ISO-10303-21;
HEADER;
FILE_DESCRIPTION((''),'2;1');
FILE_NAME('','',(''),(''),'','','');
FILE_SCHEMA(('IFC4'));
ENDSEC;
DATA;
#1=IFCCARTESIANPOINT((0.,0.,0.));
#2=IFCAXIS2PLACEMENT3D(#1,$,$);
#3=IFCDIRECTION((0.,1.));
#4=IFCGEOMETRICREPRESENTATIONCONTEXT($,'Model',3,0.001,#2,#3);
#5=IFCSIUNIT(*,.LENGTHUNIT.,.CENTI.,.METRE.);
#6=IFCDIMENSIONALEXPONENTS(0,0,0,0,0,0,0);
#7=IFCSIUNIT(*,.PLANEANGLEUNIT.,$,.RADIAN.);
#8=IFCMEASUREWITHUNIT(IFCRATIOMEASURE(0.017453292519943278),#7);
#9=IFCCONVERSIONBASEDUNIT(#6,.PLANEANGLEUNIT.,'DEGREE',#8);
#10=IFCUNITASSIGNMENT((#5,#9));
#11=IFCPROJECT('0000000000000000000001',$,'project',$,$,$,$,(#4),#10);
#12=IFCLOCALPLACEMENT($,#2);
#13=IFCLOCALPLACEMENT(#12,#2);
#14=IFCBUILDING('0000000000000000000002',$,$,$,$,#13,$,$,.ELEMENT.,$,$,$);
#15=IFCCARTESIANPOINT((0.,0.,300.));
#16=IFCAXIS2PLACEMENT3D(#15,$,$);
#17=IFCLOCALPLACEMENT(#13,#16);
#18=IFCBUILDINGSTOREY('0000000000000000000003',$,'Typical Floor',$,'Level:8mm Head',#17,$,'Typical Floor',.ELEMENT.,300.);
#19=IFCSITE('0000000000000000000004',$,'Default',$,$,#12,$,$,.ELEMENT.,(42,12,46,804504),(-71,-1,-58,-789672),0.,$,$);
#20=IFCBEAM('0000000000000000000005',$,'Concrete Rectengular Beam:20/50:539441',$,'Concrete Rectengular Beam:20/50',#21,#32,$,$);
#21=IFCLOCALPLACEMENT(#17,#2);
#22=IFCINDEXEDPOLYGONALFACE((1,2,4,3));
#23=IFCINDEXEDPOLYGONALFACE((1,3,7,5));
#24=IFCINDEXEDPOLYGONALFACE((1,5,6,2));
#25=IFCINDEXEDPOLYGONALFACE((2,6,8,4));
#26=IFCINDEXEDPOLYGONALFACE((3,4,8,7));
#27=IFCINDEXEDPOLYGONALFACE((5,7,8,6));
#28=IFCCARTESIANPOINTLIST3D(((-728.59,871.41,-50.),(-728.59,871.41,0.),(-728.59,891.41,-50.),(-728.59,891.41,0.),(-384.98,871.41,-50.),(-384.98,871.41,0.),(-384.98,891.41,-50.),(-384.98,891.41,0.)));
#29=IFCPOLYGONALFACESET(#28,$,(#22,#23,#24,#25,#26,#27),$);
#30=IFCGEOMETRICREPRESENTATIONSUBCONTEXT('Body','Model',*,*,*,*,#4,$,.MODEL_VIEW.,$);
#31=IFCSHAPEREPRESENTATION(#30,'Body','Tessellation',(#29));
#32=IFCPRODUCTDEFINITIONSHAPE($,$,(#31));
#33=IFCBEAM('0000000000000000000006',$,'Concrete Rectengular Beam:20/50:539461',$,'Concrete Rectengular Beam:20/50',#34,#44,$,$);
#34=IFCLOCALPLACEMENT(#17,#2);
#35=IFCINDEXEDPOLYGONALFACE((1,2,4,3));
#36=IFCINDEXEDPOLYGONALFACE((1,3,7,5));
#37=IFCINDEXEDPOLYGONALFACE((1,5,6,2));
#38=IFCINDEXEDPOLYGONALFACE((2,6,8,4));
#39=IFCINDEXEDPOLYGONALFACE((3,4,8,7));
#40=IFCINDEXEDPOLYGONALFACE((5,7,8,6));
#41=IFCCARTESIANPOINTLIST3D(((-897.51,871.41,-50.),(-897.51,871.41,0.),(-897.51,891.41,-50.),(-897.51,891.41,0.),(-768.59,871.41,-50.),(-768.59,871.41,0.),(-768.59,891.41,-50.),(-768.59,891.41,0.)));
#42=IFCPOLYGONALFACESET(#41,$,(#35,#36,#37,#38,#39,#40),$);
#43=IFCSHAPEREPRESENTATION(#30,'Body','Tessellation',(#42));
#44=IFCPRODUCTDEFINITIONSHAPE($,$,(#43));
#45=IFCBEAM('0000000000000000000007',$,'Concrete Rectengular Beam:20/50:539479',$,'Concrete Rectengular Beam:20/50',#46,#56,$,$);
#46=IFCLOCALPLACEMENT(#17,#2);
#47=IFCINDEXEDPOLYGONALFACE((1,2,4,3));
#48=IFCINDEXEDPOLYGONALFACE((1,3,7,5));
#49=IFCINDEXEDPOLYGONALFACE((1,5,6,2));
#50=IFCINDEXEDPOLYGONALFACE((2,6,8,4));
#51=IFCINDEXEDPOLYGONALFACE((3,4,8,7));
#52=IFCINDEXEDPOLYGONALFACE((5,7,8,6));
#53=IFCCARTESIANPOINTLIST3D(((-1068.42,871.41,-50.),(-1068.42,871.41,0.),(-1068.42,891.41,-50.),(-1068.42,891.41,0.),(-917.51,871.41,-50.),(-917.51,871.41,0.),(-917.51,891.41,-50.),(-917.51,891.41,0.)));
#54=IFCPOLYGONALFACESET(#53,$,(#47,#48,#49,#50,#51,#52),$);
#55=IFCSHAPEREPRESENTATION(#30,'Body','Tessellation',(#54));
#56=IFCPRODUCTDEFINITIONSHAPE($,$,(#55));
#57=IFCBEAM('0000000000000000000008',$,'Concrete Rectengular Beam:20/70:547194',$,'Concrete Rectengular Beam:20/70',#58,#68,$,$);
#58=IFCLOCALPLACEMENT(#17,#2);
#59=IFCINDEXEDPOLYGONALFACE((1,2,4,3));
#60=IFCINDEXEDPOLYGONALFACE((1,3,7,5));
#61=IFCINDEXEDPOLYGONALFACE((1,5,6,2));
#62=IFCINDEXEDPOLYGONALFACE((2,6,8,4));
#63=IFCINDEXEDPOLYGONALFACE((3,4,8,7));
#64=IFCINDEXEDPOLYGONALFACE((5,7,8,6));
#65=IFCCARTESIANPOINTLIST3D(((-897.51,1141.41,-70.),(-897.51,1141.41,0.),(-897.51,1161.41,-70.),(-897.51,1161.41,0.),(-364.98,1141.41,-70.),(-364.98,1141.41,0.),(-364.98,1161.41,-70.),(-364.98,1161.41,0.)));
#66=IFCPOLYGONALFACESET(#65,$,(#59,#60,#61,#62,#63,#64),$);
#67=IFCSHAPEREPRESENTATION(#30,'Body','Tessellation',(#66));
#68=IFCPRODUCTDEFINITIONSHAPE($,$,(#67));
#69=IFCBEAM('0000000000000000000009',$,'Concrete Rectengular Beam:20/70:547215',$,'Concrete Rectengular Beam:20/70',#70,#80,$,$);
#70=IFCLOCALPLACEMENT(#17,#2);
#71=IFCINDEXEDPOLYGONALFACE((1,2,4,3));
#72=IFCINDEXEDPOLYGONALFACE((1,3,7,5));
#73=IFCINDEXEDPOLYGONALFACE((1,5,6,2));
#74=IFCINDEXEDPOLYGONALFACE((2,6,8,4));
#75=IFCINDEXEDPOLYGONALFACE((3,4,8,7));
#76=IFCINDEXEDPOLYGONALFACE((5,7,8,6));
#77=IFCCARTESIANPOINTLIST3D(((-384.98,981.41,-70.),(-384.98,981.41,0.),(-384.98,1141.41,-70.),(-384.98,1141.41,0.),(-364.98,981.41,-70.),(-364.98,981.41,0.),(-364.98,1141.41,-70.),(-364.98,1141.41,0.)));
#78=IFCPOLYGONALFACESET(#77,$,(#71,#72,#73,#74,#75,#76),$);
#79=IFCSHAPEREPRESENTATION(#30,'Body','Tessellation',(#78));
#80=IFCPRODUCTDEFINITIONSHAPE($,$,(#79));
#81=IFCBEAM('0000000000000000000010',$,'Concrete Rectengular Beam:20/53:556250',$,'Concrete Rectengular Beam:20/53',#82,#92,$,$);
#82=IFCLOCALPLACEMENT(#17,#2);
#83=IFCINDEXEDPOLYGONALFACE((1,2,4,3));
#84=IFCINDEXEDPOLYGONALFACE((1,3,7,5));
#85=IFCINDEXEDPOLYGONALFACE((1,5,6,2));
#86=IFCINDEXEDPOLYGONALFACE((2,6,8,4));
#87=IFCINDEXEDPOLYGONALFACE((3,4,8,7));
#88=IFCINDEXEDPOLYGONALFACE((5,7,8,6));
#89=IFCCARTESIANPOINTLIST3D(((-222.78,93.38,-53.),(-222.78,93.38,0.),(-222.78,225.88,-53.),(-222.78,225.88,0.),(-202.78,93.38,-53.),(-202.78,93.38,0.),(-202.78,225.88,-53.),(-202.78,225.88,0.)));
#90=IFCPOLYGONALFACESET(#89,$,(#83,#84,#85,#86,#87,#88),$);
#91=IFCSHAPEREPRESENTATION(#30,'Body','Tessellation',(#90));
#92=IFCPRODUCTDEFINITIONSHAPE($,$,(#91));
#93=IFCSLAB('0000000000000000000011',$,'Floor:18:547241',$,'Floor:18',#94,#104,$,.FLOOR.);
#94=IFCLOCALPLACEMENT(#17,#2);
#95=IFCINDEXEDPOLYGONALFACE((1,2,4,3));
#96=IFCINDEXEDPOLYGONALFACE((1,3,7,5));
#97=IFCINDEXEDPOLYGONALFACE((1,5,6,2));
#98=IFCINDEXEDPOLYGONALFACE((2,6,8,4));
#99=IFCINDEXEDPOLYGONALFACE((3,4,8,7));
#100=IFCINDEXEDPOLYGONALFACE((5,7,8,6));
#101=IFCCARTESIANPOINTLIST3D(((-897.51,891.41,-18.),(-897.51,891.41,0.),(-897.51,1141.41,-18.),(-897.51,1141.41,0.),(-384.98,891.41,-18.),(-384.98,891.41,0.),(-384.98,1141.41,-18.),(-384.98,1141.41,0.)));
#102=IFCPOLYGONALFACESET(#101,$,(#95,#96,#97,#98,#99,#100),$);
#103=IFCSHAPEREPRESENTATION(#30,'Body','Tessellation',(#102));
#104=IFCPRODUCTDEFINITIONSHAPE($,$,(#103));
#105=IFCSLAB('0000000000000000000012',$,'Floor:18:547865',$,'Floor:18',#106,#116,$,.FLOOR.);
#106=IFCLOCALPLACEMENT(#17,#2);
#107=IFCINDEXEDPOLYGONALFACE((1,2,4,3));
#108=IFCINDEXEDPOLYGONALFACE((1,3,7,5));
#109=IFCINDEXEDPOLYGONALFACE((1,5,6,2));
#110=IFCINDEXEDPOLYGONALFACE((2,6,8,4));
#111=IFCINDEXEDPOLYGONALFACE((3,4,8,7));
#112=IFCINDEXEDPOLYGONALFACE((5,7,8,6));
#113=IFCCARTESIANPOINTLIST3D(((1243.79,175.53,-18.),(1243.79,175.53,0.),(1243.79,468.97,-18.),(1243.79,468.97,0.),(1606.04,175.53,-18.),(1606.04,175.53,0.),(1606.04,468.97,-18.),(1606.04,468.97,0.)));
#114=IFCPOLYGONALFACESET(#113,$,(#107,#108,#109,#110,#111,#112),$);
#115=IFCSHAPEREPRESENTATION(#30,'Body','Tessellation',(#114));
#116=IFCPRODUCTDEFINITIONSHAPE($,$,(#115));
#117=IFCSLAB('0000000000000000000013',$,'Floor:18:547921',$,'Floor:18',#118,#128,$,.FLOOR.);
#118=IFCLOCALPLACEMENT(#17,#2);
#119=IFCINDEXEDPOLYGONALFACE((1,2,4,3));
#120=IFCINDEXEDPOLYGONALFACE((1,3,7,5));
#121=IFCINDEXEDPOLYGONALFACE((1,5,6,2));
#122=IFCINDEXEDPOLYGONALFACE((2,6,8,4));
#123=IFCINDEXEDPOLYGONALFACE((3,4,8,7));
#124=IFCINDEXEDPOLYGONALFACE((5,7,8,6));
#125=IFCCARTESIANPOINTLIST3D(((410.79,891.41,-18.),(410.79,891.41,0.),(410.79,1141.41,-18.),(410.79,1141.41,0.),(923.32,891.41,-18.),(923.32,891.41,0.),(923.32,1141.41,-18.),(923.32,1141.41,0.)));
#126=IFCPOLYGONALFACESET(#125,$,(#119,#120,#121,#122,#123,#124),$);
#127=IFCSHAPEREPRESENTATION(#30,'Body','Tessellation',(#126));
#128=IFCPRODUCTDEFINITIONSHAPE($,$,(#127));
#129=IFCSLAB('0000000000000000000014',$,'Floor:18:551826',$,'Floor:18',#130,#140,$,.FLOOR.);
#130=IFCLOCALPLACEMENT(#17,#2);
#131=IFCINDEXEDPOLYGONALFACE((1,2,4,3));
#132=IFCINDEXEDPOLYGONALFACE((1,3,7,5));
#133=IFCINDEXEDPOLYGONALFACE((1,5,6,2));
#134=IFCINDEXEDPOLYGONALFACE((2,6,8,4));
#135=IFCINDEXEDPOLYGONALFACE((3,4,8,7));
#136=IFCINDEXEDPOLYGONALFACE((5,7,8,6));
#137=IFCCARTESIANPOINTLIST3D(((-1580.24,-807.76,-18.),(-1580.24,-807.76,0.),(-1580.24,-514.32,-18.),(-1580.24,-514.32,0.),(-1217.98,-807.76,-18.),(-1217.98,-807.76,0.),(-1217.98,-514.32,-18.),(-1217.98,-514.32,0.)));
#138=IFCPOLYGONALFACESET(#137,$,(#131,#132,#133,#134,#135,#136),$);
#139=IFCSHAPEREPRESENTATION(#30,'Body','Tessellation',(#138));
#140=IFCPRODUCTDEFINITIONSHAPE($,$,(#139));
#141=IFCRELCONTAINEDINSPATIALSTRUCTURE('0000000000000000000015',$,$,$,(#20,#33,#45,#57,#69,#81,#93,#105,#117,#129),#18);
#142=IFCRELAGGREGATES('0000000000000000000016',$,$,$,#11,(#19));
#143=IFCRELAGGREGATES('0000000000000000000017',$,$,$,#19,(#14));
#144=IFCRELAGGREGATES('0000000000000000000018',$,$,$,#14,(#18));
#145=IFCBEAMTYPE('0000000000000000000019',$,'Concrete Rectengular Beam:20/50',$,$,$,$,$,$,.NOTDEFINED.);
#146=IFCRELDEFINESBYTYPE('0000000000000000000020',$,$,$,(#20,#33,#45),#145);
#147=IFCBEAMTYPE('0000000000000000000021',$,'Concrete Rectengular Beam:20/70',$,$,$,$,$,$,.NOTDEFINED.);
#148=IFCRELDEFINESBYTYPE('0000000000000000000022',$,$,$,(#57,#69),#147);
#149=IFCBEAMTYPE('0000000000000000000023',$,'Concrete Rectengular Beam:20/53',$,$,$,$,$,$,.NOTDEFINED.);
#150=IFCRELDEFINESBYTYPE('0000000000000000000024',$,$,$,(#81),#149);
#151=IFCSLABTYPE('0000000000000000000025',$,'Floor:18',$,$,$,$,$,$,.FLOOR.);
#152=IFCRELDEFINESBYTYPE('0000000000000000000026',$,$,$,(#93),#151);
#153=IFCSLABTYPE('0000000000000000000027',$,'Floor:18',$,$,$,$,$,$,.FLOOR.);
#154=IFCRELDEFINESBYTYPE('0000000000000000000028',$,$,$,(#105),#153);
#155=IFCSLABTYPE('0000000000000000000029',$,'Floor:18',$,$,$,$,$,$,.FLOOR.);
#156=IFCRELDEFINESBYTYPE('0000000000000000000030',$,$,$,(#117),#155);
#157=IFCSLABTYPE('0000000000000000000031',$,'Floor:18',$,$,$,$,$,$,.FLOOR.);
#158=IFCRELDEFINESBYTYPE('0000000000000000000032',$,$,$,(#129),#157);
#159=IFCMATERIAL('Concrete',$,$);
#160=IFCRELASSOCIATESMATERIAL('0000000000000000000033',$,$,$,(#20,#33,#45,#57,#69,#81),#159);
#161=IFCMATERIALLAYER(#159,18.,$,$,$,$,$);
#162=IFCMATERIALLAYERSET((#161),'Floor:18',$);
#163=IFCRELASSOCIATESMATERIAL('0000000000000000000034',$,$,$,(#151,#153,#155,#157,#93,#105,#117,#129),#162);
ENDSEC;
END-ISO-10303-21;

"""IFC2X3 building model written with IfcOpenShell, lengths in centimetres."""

from ifc_helpers import new_model, entity, si_unit, converted_unit, direction, frame, frame_2d, origin, origin_2d_with_axis, place, context, subcontext, project, spatial, rectangle, extrude, material, layer, layer_set, layer_usage, type_object, element, save


model = new_model("IFC2X3")

# Units and contexts
model_context = context("Model", 3, precision=0.001, world=origin(), true_north=direction((0.0, 1.0)))
body_context = subcontext(model_context, "Body", "Model", "MODEL_VIEW")
ifc_project = project(units=[si_unit("LENGTHUNIT", "METRE", prefix="CENTI"), converted_unit("PLANEANGLEUNIT", "DEGREE", entity("IfcRatioMeasure", 0.017453292519943278), si_unit("PLANEANGLEUNIT", "RADIAN"), dimensions=[0, 0, 0, 0, 0, 0, 0])], contexts=[model_context])

# Site, building, storey
site_placement = place(None, origin())
site = spatial("IfcSite", under=ifc_project, at=site_placement, Name="Default", CompositionType="ELEMENT", RefLatitude=(42, 12, 46, 804504), RefLongitude=(-71, -1, -58, -789672), RefElevation=0.0)
building_placement = place(site_placement, origin())
building = spatial("IfcBuilding", under=site, at=building_placement, CompositionType="ELEMENT")
storey_placement = place(building_placement, frame((0.0, 0.0, 300.0)))
storey = spatial("IfcBuildingStorey", under=building, at=storey_placement, Name="Typical Floor", ObjectType="Level:8mm Head", LongName="Typical Floor", CompositionType="ELEMENT", Elevation=300.0)

# Beams
ifc_material = material(Name="Concrete")
beam_type_1 = type_object("IfcBeamType", Name="Concrete Rectengular Beam:20/50", PredefinedType="NOTDEFINED")
beam_1_placement = place(storey_placement, frame((-374.98, 881.41, 0.0), z_axis=(0.0, 0.0, 1.0), x_axis=(-1.0, 0.0, 0.0)))
element("IfcBeam", 1, at=beam_1_placement, inside=storey, type_object=beam_type_1, material=ifc_material, Name="Concrete Rectengular Beam:20/50:539441", ObjectType="Concrete Rectengular Beam:20/50", context=body_context, shape_type="SweptSolid", body=[
    extrude(rectangle(XDim=50.0, YDim=20.0, at=frame_2d((0.0, 0.0), x_axis=(1.0, 0.0))), frame((10.0, 0.0, -25.0), z_axis=(1.0, 0.0, 0.0), x_axis=(0.0, 0.0, -1.0)), (0.0, 0.0, 1.0), 343.61),
])
beam_2_placement = place(storey_placement, frame((-748.59, 881.41, 0.0), z_axis=(0.0, 0.0, 1.0), x_axis=(-1.0, 0.0, 0.0)))
element("IfcBeam", 2, at=beam_2_placement, inside=storey, type_object=beam_type_1, material=ifc_material, Name="Concrete Rectengular Beam:20/50:539461", ObjectType="Concrete Rectengular Beam:20/50", context=body_context, shape_type="SweptSolid", body=[
    extrude(rectangle(XDim=50.0, YDim=20.0, at=frame_2d((0.0, 0.0), x_axis=(1.0, 0.0))), frame((20.0, 0.0, -25.0), z_axis=(1.0, 0.0, 0.0), x_axis=(0.0, 0.0, -1.0)), (0.0, 0.0, 1.0), 128.92),
])
beam_3_placement = place(storey_placement, frame((-907.51, 881.41, 0.0), z_axis=(0.0, 0.0, 1.0), x_axis=(-1.0, 0.0, 0.0)))
element("IfcBeam", 3, at=beam_3_placement, inside=storey, type_object=beam_type_1, material=ifc_material, Name="Concrete Rectengular Beam:20/50:539479", ObjectType="Concrete Rectengular Beam:20/50", context=body_context, shape_type="SweptSolid", body=[
    extrude(rectangle(XDim=50.0, YDim=20.0, at=frame_2d((0.0, 0.0), x_axis=(1.0, 0.0))), frame((10.0, 0.0, -25.0), z_axis=(1.0, 0.0, 0.0), x_axis=(0.0, 0.0, -1.0)), (0.0, 0.0, 1.0), 150.91),
])
beam_type_2 = type_object("IfcBeamType", Name="Concrete Rectengular Beam:20/70", PredefinedType="NOTDEFINED")
beam_4_placement = place(storey_placement, frame((-907.51, 1151.41, 0.0)))
element("IfcBeam", 4, at=beam_4_placement, inside=storey, type_object=beam_type_2, material=ifc_material, Name="Concrete Rectengular Beam:20/70:547194", ObjectType="Concrete Rectengular Beam:20/70", context=body_context, shape_type="SweptSolid", body=[
    extrude(rectangle(XDim=70.0, YDim=20.0, at=frame_2d((0.0, 0.0), x_axis=(1.0, 0.0))), frame((10.0, 0.0, -35.0), z_axis=(1.0, 0.0, 0.0), x_axis=(0.0, 0.0, -1.0)), (0.0, 0.0, 1.0), 532.53),
])
beam_5_placement = place(storey_placement, frame((-374.98, 1151.41, 0.0), z_axis=(0.0, 0.0, 1.0), x_axis=(0.0, -1.0, 0.0)))
element("IfcBeam", 5, at=beam_5_placement, inside=storey, type_object=beam_type_2, material=ifc_material, Name="Concrete Rectengular Beam:20/70:547215", ObjectType="Concrete Rectengular Beam:20/70", context=body_context, shape_type="SweptSolid", body=[
    extrude(rectangle(XDim=70.0, YDim=20.0, at=origin_2d_with_axis()), frame((10.0, 0.0, -35.0), z_axis=(1.0, 0.0, 0.0), x_axis=(0.0, 0.0, -1.0)), (0.0, 0.0, 1.0), 160.0),
])
beam_type_3 = type_object("IfcBeamType", Name="Concrete Rectengular Beam:20/53", PredefinedType="NOTDEFINED")
beam_6_placement = place(storey_placement, frame((-212.78, 225.88, 0.0), z_axis=(0.0, 0.0, 1.0), x_axis=(0.0, -1.0, 0.0)))
element("IfcBeam", 6, at=beam_6_placement, inside=storey, type_object=beam_type_3, material=ifc_material, Name="Concrete Rectengular Beam:20/53:556250", ObjectType="Concrete Rectengular Beam:20/53", context=body_context, shape_type="SweptSolid", body=[
    extrude(rectangle(XDim=53.0, YDim=20.0, at=origin_2d_with_axis()), frame((0.0, 0.0, -26.5), z_axis=(1.0, 0.0, 0.0), x_axis=(0.0, 0.0, -1.0)), (0.0, 0.0, 1.0), 132.5),
])

# Slabs
ifc_layer = layer(ifc_material, 18.0)
ifc_layer_set = layer_set([ifc_layer], Name="Floor:18")
ifc_layer_usage_1 = layer_usage(ifc_layer_set, "AXIS3", "POSITIVE", 0.0)
slab_type_1 = type_object("IfcSlabType", Name="Floor:18", PredefinedType="FLOOR", material=ifc_layer_set)
slab_1_placement = place(storey_placement, origin())
element("IfcSlab", 7, at=slab_1_placement, inside=storey, type_object=slab_type_1, material=ifc_layer_usage_1, Name="Floor:18:547241", ObjectType="Floor:18", PredefinedType="FLOOR", context=body_context, shape_type="SweptSolid", body=[
    extrude(rectangle(XDim=250.0, YDim=512.53, at=frame_2d((0.0, 0.0), x_axis=(1.0, 0.0))), frame((-641.25, 1016.41, 0.0), z_axis=(0.0, 0.0, -1.0), x_axis=(0.0, 1.0, 0.0)), (0.0, 0.0, 1.0), 18.0),
])
ifc_layer_usage_2 = layer_usage(ifc_layer_set, "AXIS3", "POSITIVE", 0.0)
slab_type_2 = type_object("IfcSlabType", Name="Floor:18", PredefinedType="FLOOR", material=ifc_layer_set)
slab_2_placement = place(storey_placement, origin())
element("IfcSlab", 8, at=slab_2_placement, inside=storey, type_object=slab_type_2, material=ifc_layer_usage_2, Name="Floor:18:547865", ObjectType="Floor:18", PredefinedType="FLOOR", context=body_context, shape_type="SweptSolid", body=[
    extrude(rectangle(XDim=293.44, YDim=362.26, at=frame_2d((0.0, 0.0), x_axis=(1.0, 0.0))), frame((1424.92, 322.25, 0.0), z_axis=(0.0, 0.0, -1.0), x_axis=(0.0, 1.0, 0.0)), (0.0, 0.0, 1.0), 18.0),
])
ifc_layer_usage_3 = layer_usage(ifc_layer_set, "AXIS3", "POSITIVE", 0.0)
slab_type_3 = type_object("IfcSlabType", Name="Floor:18", PredefinedType="FLOOR", material=ifc_layer_set)
slab_3_placement = place(storey_placement, origin())
element("IfcSlab", 9, at=slab_3_placement, inside=storey, type_object=slab_type_3, material=ifc_layer_usage_3, Name="Floor:18:547921", ObjectType="Floor:18", PredefinedType="FLOOR", context=body_context, shape_type="SweptSolid", body=[
    extrude(rectangle(XDim=250.0, YDim=512.53, at=frame_2d((0.0, 0.0), x_axis=(1.0, 0.0))), frame((667.05, 1016.41, 0.0), z_axis=(0.0, 0.0, -1.0), x_axis=(0.0, 1.0, 0.0)), (0.0, 0.0, 1.0), 18.0),
])
ifc_layer_usage_4 = layer_usage(ifc_layer_set, "AXIS3", "POSITIVE", 0.0)
slab_type_4 = type_object("IfcSlabType", Name="Floor:18", PredefinedType="FLOOR", material=ifc_layer_set)
slab_4_placement = place(storey_placement, origin())
element("IfcSlab", 10, at=slab_4_placement, inside=storey, type_object=slab_type_4, material=ifc_layer_usage_4, Name="Floor:18:551826", ObjectType="Floor:18", PredefinedType="FLOOR", context=body_context, shape_type="SweptSolid", body=[
    extrude(rectangle(XDim=293.44, YDim=362.26, at=frame_2d((0.0, 0.0), x_axis=(1.0, 0.0))), frame((-1399.11, -661.04, 0.0), z_axis=(0.0, 0.0, -1.0), x_axis=(0.0, 1.0, 0.0)), (0.0, 0.0, 1.0), 18.0),
])

save(model, "model.ifc")
